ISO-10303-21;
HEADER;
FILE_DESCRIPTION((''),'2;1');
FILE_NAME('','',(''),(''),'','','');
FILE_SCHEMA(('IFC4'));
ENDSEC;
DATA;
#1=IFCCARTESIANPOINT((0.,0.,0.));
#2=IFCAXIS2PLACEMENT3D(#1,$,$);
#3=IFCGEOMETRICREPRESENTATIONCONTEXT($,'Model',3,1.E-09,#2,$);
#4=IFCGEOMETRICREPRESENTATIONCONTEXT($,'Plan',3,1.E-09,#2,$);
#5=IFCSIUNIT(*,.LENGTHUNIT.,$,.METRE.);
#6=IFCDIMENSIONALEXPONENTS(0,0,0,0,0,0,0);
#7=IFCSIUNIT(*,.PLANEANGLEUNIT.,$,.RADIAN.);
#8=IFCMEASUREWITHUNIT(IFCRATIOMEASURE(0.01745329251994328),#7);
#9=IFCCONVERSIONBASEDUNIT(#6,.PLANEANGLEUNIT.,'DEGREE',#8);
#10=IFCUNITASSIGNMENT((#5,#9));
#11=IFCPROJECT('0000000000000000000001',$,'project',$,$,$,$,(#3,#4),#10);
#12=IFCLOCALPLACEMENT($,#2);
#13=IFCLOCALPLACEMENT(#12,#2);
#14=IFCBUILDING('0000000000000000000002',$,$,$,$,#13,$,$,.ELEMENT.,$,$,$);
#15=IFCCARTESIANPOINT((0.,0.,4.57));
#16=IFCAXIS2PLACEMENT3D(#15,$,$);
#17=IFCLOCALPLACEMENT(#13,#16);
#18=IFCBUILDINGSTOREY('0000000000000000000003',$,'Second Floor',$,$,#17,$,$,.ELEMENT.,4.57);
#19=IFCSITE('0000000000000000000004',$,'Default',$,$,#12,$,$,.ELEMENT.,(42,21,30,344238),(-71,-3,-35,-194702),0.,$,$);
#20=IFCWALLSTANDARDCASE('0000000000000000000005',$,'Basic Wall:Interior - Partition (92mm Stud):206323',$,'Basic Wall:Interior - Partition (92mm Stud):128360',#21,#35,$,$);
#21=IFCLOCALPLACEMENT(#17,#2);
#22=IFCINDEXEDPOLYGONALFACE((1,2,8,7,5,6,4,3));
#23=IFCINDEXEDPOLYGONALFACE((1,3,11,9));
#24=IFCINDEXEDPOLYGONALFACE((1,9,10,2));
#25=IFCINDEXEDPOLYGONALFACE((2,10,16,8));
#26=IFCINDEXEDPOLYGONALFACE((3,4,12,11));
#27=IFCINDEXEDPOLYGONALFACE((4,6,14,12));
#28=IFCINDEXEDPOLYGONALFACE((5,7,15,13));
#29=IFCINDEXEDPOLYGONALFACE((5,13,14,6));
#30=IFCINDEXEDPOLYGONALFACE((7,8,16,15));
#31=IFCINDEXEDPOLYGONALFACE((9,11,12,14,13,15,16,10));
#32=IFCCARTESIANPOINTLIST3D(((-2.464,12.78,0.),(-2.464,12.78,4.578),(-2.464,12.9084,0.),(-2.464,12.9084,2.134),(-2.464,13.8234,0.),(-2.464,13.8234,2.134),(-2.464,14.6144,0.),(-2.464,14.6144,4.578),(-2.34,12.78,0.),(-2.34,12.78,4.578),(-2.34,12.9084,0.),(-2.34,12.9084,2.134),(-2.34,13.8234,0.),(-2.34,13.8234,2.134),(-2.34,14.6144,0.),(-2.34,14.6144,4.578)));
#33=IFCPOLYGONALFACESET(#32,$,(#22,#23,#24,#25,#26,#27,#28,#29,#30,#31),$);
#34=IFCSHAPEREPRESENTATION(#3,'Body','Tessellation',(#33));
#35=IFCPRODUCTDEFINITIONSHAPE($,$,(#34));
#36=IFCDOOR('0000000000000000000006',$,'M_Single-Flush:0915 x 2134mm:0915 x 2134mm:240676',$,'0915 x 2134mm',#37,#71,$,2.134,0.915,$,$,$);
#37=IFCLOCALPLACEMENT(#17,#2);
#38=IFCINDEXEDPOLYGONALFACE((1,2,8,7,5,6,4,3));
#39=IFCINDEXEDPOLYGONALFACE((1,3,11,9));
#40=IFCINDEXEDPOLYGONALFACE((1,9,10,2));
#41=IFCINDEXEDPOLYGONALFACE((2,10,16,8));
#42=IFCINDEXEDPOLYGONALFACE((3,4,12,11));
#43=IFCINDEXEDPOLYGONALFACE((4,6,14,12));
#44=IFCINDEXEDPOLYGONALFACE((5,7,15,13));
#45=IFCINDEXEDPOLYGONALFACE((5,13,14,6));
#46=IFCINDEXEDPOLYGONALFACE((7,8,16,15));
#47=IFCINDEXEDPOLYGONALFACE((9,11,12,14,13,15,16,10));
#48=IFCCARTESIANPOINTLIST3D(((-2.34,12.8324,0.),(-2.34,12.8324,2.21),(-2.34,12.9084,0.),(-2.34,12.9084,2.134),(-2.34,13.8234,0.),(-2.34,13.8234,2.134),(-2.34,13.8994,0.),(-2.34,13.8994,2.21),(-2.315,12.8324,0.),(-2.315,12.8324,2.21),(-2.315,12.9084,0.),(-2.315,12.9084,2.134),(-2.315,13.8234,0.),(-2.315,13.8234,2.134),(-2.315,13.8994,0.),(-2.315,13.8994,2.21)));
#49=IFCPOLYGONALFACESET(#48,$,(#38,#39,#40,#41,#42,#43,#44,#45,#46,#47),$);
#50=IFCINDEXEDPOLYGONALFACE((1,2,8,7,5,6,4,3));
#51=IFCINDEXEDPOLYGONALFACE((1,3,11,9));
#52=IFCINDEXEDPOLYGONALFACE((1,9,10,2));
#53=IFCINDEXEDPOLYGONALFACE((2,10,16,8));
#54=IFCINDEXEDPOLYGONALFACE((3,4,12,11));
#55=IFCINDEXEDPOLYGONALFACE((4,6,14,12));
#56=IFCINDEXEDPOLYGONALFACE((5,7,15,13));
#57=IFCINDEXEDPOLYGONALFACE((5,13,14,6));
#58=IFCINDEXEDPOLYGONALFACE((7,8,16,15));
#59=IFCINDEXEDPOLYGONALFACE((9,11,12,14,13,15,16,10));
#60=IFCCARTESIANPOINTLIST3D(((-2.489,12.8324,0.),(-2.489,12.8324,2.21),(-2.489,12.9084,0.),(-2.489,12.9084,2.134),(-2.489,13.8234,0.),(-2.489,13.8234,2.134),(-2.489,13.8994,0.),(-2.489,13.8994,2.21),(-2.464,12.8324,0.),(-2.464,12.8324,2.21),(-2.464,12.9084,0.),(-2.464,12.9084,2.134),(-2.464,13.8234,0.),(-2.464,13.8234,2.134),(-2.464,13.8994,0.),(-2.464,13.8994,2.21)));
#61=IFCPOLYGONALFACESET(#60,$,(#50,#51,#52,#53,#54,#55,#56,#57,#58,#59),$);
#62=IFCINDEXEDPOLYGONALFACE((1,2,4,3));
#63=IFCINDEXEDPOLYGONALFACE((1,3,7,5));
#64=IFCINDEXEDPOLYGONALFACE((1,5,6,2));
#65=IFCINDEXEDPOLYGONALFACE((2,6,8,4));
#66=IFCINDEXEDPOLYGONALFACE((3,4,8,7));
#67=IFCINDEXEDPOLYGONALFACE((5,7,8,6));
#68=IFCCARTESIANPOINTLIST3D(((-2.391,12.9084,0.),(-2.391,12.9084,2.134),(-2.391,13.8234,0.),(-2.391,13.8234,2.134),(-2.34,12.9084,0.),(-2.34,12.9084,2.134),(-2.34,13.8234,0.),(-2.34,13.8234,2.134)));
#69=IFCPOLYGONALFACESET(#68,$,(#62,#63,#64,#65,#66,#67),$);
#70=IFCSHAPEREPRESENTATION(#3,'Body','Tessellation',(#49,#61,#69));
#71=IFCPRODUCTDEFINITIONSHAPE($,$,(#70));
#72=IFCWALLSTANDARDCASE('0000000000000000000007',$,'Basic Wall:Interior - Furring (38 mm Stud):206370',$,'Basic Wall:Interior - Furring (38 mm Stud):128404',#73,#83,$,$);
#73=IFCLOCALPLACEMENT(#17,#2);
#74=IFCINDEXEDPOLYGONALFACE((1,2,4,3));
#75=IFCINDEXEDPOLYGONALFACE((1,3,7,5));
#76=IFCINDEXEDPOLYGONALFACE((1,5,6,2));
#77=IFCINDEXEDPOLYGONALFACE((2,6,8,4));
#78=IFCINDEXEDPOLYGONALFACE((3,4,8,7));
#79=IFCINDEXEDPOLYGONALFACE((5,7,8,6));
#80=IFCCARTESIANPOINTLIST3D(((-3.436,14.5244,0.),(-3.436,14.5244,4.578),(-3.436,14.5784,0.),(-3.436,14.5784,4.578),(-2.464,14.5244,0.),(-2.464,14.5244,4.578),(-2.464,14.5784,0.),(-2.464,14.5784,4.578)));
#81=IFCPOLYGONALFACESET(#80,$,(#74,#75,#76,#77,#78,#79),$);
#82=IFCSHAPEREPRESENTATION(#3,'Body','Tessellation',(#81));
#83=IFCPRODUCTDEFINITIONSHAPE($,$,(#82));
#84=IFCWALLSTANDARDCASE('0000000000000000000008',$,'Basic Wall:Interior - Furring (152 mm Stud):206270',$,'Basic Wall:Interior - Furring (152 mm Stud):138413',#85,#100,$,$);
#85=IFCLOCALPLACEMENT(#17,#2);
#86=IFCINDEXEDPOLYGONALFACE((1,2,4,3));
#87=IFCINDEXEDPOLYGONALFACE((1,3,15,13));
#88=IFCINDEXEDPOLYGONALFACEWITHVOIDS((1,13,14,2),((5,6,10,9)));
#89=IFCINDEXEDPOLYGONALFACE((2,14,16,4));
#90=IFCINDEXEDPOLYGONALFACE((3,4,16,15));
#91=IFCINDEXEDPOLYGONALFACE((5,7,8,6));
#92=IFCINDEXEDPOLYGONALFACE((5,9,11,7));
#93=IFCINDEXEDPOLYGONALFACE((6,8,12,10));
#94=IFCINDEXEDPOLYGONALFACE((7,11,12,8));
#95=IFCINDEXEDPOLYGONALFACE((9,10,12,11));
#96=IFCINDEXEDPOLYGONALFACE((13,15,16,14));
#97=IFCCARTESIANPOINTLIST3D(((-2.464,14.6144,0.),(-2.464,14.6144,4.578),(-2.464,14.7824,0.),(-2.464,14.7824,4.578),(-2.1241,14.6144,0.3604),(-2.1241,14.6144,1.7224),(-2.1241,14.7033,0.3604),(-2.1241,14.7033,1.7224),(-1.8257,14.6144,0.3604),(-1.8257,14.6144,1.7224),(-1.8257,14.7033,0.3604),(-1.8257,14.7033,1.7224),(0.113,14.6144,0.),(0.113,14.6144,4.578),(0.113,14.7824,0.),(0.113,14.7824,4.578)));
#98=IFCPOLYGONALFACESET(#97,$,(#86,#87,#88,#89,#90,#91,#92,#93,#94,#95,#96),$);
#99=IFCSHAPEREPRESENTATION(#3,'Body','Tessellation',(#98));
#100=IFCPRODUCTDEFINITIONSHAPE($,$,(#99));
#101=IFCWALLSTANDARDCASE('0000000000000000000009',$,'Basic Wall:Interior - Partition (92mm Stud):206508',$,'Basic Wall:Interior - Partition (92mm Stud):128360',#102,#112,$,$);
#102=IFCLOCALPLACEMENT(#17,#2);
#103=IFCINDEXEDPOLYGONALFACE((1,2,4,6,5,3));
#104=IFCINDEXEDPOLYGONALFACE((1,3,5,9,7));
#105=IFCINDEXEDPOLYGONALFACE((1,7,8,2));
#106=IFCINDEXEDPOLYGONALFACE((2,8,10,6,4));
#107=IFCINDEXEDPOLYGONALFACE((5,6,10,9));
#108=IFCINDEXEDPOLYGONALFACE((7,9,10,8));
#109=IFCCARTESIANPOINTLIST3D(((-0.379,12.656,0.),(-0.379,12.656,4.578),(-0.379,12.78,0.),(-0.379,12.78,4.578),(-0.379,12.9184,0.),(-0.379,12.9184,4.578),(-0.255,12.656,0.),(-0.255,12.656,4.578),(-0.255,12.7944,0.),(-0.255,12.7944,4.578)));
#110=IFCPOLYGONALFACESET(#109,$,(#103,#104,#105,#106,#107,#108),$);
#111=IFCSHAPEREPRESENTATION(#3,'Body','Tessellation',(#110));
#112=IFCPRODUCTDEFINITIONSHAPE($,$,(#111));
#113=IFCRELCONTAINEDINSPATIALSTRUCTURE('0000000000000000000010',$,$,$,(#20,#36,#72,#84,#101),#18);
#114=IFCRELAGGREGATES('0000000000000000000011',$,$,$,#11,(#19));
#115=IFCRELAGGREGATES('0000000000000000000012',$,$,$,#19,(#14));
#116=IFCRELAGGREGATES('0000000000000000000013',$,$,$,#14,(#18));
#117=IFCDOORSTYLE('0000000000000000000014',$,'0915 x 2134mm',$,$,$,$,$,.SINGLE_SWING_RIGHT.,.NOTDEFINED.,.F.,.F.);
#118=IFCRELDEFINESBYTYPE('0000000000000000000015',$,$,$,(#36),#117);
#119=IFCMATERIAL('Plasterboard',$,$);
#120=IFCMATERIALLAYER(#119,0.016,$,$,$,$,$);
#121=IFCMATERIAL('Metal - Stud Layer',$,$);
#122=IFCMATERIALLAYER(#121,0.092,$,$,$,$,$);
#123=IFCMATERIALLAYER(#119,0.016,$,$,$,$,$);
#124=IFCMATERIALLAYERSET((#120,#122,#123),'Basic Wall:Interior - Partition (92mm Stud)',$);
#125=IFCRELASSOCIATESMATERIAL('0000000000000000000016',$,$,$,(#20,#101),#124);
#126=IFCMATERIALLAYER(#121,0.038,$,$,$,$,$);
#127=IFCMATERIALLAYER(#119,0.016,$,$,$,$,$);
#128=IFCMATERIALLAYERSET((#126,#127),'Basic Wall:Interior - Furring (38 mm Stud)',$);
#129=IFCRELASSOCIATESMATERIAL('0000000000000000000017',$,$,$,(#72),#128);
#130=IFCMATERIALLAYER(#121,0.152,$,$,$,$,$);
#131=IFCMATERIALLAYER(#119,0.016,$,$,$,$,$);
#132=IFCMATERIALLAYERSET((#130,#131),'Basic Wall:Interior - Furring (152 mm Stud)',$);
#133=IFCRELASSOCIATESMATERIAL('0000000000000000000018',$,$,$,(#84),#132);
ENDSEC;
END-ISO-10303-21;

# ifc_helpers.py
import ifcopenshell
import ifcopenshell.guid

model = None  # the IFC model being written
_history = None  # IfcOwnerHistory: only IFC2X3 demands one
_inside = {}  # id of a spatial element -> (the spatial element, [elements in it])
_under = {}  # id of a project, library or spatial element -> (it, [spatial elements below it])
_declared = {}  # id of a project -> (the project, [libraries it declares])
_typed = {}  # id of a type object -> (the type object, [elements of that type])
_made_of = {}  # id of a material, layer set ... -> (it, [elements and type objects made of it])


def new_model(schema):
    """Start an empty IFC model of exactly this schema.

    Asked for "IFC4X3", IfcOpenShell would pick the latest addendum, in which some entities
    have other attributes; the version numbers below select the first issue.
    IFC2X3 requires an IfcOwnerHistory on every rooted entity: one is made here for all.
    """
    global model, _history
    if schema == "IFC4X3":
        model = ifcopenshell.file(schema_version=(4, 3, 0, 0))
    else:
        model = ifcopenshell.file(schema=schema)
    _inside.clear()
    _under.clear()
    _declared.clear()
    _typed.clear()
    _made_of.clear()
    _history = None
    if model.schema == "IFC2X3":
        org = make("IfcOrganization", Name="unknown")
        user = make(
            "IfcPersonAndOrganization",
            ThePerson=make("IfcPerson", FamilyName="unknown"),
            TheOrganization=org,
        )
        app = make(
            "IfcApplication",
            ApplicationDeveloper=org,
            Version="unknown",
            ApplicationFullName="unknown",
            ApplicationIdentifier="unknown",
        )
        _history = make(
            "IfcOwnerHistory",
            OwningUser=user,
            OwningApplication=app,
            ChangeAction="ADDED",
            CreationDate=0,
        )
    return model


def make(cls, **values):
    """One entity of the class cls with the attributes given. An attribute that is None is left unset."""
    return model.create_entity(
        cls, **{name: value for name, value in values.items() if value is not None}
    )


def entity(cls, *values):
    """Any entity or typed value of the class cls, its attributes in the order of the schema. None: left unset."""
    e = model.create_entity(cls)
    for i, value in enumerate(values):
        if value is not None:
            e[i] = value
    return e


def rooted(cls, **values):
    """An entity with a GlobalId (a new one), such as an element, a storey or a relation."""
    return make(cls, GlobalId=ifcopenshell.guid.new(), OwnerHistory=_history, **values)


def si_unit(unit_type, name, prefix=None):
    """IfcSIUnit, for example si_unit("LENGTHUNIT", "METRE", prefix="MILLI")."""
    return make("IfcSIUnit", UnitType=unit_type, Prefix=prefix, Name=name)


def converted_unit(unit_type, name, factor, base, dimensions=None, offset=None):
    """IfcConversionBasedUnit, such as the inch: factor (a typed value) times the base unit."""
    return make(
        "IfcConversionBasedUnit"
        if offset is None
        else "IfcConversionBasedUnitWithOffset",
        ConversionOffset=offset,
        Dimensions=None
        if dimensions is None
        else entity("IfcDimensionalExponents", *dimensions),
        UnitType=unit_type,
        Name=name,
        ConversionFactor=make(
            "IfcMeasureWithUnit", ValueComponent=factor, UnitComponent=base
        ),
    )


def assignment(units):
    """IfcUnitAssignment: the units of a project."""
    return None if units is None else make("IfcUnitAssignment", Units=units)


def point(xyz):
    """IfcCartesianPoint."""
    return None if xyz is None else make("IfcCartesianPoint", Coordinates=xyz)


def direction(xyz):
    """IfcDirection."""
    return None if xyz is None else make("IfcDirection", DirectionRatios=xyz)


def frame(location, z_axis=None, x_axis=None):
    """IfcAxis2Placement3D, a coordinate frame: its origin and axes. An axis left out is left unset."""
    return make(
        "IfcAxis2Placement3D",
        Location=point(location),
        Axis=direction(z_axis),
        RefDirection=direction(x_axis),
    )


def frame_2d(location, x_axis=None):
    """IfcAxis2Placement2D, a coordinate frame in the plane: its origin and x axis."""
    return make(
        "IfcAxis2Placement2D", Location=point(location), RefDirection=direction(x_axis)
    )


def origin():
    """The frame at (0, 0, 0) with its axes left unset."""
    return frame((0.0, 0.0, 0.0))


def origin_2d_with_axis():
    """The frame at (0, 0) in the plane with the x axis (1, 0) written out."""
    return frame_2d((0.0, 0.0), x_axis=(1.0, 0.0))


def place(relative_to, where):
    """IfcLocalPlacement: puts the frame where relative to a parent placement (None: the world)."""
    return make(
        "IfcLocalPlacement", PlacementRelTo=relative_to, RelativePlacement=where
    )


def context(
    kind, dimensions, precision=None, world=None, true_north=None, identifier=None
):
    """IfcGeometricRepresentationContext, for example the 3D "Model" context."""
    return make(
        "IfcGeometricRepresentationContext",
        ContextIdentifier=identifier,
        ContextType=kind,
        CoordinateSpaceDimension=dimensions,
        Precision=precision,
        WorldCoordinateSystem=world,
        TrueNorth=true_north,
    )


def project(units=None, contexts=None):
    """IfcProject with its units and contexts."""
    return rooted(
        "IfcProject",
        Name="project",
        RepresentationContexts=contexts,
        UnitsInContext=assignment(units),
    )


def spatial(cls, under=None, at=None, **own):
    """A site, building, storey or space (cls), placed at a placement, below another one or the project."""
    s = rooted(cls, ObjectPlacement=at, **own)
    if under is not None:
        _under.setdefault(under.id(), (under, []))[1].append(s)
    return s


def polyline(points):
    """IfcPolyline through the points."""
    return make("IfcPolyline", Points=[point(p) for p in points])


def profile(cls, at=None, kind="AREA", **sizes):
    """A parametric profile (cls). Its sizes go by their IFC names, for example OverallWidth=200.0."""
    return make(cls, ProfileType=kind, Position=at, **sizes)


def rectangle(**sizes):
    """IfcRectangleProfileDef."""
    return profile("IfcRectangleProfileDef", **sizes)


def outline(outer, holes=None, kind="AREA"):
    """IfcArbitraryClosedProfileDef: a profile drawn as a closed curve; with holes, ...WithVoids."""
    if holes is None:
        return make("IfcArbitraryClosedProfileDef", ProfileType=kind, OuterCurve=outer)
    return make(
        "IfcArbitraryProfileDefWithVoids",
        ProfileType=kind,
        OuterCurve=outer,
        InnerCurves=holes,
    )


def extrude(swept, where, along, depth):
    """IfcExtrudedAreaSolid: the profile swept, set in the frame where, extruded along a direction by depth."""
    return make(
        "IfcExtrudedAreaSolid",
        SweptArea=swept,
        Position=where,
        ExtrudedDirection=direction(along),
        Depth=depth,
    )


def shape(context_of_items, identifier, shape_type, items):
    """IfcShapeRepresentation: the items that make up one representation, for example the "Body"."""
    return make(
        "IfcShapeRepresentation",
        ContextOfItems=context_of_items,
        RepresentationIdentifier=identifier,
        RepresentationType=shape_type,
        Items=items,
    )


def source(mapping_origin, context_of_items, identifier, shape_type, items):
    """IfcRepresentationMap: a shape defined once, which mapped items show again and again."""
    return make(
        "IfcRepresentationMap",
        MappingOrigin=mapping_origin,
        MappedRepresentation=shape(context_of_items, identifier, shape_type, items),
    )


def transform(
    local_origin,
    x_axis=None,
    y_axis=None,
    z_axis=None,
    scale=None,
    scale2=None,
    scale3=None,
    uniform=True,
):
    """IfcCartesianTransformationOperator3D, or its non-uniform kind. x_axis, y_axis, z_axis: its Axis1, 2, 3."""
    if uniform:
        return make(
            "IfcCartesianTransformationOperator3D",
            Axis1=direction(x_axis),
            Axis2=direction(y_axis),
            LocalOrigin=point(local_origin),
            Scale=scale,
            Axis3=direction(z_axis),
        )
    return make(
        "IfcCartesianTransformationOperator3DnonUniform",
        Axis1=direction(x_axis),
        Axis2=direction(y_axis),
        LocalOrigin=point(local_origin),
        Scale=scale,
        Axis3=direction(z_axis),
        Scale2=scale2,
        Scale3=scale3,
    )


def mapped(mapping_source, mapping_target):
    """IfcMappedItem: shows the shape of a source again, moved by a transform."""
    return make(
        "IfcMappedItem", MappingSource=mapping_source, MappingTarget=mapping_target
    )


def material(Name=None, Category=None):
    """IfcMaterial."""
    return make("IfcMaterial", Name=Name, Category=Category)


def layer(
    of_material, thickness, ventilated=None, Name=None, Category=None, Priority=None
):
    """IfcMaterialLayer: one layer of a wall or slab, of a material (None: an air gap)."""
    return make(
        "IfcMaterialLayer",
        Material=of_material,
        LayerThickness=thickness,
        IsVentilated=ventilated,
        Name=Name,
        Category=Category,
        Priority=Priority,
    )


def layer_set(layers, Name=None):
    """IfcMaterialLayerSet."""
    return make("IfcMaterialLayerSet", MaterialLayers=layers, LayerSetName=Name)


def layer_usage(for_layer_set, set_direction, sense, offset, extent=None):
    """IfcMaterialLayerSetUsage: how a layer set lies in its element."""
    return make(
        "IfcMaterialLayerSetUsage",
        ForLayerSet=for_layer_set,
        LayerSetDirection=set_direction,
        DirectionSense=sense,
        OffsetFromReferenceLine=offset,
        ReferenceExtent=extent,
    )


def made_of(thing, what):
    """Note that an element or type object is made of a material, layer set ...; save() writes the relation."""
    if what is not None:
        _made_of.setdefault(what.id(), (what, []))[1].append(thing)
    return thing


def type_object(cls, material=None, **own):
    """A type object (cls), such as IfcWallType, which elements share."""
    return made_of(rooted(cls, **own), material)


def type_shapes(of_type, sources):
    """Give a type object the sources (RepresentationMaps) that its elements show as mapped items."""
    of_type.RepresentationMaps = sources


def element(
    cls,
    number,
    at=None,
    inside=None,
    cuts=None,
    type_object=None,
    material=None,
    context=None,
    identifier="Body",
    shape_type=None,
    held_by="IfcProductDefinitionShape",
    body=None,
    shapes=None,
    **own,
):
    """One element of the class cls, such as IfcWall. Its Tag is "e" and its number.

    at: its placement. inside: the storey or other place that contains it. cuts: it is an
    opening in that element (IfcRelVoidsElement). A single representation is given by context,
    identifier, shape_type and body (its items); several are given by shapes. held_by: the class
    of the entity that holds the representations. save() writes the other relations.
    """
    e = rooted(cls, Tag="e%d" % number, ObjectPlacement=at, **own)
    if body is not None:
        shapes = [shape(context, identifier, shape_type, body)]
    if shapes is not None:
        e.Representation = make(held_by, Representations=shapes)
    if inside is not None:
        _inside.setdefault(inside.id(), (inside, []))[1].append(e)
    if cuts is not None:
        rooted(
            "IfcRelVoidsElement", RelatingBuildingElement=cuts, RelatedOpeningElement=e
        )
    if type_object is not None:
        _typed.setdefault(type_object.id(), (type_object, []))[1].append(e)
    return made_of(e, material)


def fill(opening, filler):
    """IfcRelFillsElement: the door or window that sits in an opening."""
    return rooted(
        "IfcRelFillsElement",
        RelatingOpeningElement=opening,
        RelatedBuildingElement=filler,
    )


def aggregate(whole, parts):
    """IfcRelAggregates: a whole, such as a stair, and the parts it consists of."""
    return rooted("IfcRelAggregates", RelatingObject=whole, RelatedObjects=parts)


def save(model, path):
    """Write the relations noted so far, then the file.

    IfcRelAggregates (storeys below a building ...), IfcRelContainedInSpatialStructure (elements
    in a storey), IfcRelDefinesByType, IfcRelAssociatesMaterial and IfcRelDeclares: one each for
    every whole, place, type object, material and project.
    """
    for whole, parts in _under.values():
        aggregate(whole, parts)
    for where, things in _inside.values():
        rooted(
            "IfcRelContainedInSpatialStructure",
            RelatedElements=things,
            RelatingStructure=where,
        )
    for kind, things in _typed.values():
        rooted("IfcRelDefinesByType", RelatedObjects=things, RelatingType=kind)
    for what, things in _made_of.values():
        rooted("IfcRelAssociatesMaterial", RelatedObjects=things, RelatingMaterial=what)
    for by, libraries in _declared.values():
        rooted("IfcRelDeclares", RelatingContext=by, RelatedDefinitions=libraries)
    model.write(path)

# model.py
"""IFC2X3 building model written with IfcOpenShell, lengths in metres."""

from ifc_helpers import new_model, entity, si_unit, converted_unit, frame, frame_2d, origin, origin_2d_with_axis, place, context, project, spatial, polyline, rectangle, outline, extrude, source, transform, mapped, material, layer, layer_set, layer_usage, type_object, type_shapes, element, fill, save


model = new_model("IFC2X3")

# Units and contexts
model_context = context("Model", 3, precision=1e-09, world=origin())
plan_context = context("Plan", 3, precision=1e-09, world=origin())
ifc_project = project(units=[si_unit("LENGTHUNIT", "METRE"), converted_unit("PLANEANGLEUNIT", "DEGREE", entity("IfcRatioMeasure", 0.01745329251994328), si_unit("PLANEANGLEUNIT", "RADIAN"), dimensions=[0, 0, 0, 0, 0, 0, 0])], contexts=[model_context, plan_context])

# Site, building, storey
site_placement = place(None, origin())
site = spatial("IfcSite", under=ifc_project, at=site_placement, Name="Default", CompositionType="ELEMENT", RefLatitude=(42, 21, 30, 344238), RefLongitude=(-71, -3, -35, -194702), RefElevation=0.0)
building_placement = place(site_placement, origin())
building = spatial("IfcBuilding", under=site, at=building_placement, CompositionType="ELEMENT")
storey_placement = place(building_placement, frame((0.0, 0.0, 4.57)))
storey = spatial("IfcBuildingStorey", under=building, at=storey_placement, Name="Second Floor", CompositionType="ELEMENT", Elevation=4.57)

# Wall, opening, door
ifc_material_1 = material(Name="Plasterboard")
ifc_layer_1 = layer(ifc_material_1, 0.016)
ifc_material_2 = material(Name="Metal - Stud Layer")
ifc_layer_2 = layer(ifc_material_2, 0.092)
ifc_layer_3 = layer(ifc_material_1, 0.016)
ifc_layer_set_1 = layer_set([ifc_layer_1, ifc_layer_2, ifc_layer_3], Name="Basic Wall:Interior - Partition (92mm Stud)")
ifc_layer_usage_1 = layer_usage(ifc_layer_set_1, "AXIS2", "NEGATIVE", 0.062)
wall_1_placement = place(storey_placement, frame((-2.402, 14.6144, 0.0), z_axis=(0.0, 0.0, 1.0), x_axis=(0.0, -1.0, 0.0)))
wall_1 = element("IfcWallStandardCase", 1, at=wall_1_placement, inside=storey, material=ifc_layer_usage_1, Name="Basic Wall:Interior - Partition (92mm Stud):206323", ObjectType="Basic Wall:Interior - Partition (92mm Stud):128360", context=model_context, shape_type="SweptSolid", body=[
    extrude(rectangle(XDim=1.8344, YDim=0.124, at=frame_2d((0.9172, 0.0), x_axis=(-1.0, 0.0))), origin(), (0.0, 0.0, 1.0), 4.578),
])
opening_1_placement = place(wall_1_placement, frame((0.791, -0.062, 0.0)))
opening_1 = element("IfcOpeningElement", 2, at=opening_1_placement, cuts=wall_1, ObjectType="Opening", context=model_context, shape_type="SweptSolid", body=[
    extrude(rectangle(XDim=0.915, YDim=2.134, at=frame_2d((1.067, 0.4575), x_axis=(0.0, 1.0))), frame((0.0, 0.0, 0.0), z_axis=(0.0, 1.0, 0.0), x_axis=(0.0, 0.0, 1.0)), (0.0, 0.0, 1.0), 0.124),
])
door_style = type_object("IfcDoorStyle", Name="0915 x 2134mm", ConstructionType="NOTDEFINED", OperationType="SINGLE_SWING_RIGHT", ParameterTakesPrecedence=False, Sizeable=False)
shared_shape_1 = source(origin(), model_context, "Body", "SweptSolid", [
    extrude(outline(polyline([(-0.5335, -1.124), (0.5335, -1.124), (0.5335, 1.086), (0.4575, 1.086), (0.4575, -1.048), (-0.4575, -1.048), (-0.4575, 1.086), (-0.5335, 1.086), (-0.5335, -1.124)])), frame((0.4575, 0.124, 1.086), z_axis=(0.0, 1.0, 0.0), x_axis=(1.0, 0.0, 0.0)), (0.0, 0.0, 1.0), 0.025),
    extrude(outline(polyline([(-1.124, -0.5335), (1.086, -0.5335), (1.086, -0.4575), (-1.048, -0.4575), (-1.048, 0.4575), (1.086, 0.4575), (1.086, 0.5335), (-1.124, 0.5335), (-1.124, -0.5335)])), frame((0.4575, -0.025, 1.086), z_axis=(0.0, 1.0, 0.0), x_axis=(0.0, 0.0, -1.0)), (0.0, 0.0, 1.0), 0.025),
    extrude(rectangle(XDim=0.051, YDim=0.915, at=origin_2d_with_axis()), frame((0.4575, 0.0985, 0.0), z_axis=(0.0, 0.0, 1.0), x_axis=(0.0, 1.0, 0.0)), (0.0, 0.0, 1.0), 2.134),
])
type_shapes(door_style, [shared_shape_1])
door_placement = place(opening_1_placement, origin())
door = element("IfcDoor", 3, at=door_placement, inside=storey, type_object=door_style, Name="M_Single-Flush:0915 x 2134mm:0915 x 2134mm:240676", ObjectType="0915 x 2134mm", OverallHeight=2.134, OverallWidth=0.915, context=model_context, shape_type="MappedRepresentation", body=[
    mapped(shared_shape_1, transform((0.0, 0.0, 0.0), scale=1.0)),
])
fill(opening_1, door)

# Wall
ifc_layer_4 = layer(ifc_material_2, 0.038)
ifc_layer_5 = layer(ifc_material_1, 0.016)
ifc_layer_set_2 = layer_set([ifc_layer_4, ifc_layer_5], Name="Basic Wall:Interior - Furring (38 mm Stud)")
ifc_layer_usage_2 = layer_usage(ifc_layer_set_2, "AXIS2", "POSITIVE", -0.027)
wall_2_placement = place(storey_placement, frame((-2.464, 14.5514, 0.0), z_axis=(0.0, 0.0, 1.0), x_axis=(-1.0, 0.0, 0.0)))
element("IfcWallStandardCase", 4, at=wall_2_placement, inside=storey, material=ifc_layer_usage_2, Name="Basic Wall:Interior - Furring (38 mm Stud):206370", ObjectType="Basic Wall:Interior - Furring (38 mm Stud):128404", context=model_context, shape_type="SweptSolid", body=[
    extrude(rectangle(XDim=0.972, YDim=0.054, at=frame_2d((0.486, 0.0), x_axis=(-1.0, 0.0))), origin(), (0.0, 0.0, 1.0), 4.578),
])

# Wall, opening
ifc_layer_6 = layer(ifc_material_2, 0.152)
ifc_layer_7 = layer(ifc_material_1, 0.016)
ifc_layer_set_3 = layer_set([ifc_layer_6, ifc_layer_7], Name="Basic Wall:Interior - Furring (152 mm Stud)")
ifc_layer_usage_3 = layer_usage(ifc_layer_set_3, "AXIS2", "POSITIVE", -0.084)
wall_3_placement = place(storey_placement, frame((0.113, 14.6984, 0.0), z_axis=(0.0, 0.0, 1.0), x_axis=(-1.0, 0.0, 0.0)))
wall_3 = element("IfcWallStandardCase", 5, at=wall_3_placement, inside=storey, material=ifc_layer_usage_3, Name="Basic Wall:Interior - Furring (152 mm Stud):206270", ObjectType="Basic Wall:Interior - Furring (152 mm Stud):138413", context=model_context, shape_type="SweptSolid", body=[
    extrude(rectangle(XDim=2.577, YDim=0.168, at=frame_2d((1.2885, 0.0), x_axis=(-1.0, 0.0))), origin(), (0.0, 0.0, 1.0), 4.578),
])
opening_2_placement = place(wall_3_placement, origin())
element("IfcOpeningElement", 6, at=opening_2_placement, cuts=wall_3, ObjectType="Opening", context=model_context, shape_type="SweptSolid", body=[
    extrude(rectangle(XDim=1.3621, YDim=0.2985, at=frame_2d((0.0, 0.0), x_axis=(0.0, 1.0))), frame((2.0879, -0.0049, 1.0414), z_axis=(0.0, 1.0, 0.0), x_axis=(1.0, 0.0, 0.0)), (0.0, 0.0, 1.0), 0.1524),
])

# Wall
wall_4_placement = place(storey_placement, frame((-0.317, 12.9184, 0.0), z_axis=(0.0, 0.0, 1.0), x_axis=(0.0, -1.0, 0.0)))
element("IfcWallStandardCase", 7, at=wall_4_placement, inside=storey, material=ifc_layer_usage_1, Name="Basic Wall:Interior - Partition (92mm Stud):206508", ObjectType="Basic Wall:Interior - Partition (92mm Stud):128360", context=model_context, shape_type="SweptSolid", body=[
    extrude(outline(polyline([(0.2624, -0.062), (0.2624, 0.062), (0.124, 0.062), (0.0, -0.062), (0.1384, -0.062), (0.2624, -0.062)])), origin(), (0.0, 0.0, 1.0), 4.578),
])

save(model, "model.ifc")
